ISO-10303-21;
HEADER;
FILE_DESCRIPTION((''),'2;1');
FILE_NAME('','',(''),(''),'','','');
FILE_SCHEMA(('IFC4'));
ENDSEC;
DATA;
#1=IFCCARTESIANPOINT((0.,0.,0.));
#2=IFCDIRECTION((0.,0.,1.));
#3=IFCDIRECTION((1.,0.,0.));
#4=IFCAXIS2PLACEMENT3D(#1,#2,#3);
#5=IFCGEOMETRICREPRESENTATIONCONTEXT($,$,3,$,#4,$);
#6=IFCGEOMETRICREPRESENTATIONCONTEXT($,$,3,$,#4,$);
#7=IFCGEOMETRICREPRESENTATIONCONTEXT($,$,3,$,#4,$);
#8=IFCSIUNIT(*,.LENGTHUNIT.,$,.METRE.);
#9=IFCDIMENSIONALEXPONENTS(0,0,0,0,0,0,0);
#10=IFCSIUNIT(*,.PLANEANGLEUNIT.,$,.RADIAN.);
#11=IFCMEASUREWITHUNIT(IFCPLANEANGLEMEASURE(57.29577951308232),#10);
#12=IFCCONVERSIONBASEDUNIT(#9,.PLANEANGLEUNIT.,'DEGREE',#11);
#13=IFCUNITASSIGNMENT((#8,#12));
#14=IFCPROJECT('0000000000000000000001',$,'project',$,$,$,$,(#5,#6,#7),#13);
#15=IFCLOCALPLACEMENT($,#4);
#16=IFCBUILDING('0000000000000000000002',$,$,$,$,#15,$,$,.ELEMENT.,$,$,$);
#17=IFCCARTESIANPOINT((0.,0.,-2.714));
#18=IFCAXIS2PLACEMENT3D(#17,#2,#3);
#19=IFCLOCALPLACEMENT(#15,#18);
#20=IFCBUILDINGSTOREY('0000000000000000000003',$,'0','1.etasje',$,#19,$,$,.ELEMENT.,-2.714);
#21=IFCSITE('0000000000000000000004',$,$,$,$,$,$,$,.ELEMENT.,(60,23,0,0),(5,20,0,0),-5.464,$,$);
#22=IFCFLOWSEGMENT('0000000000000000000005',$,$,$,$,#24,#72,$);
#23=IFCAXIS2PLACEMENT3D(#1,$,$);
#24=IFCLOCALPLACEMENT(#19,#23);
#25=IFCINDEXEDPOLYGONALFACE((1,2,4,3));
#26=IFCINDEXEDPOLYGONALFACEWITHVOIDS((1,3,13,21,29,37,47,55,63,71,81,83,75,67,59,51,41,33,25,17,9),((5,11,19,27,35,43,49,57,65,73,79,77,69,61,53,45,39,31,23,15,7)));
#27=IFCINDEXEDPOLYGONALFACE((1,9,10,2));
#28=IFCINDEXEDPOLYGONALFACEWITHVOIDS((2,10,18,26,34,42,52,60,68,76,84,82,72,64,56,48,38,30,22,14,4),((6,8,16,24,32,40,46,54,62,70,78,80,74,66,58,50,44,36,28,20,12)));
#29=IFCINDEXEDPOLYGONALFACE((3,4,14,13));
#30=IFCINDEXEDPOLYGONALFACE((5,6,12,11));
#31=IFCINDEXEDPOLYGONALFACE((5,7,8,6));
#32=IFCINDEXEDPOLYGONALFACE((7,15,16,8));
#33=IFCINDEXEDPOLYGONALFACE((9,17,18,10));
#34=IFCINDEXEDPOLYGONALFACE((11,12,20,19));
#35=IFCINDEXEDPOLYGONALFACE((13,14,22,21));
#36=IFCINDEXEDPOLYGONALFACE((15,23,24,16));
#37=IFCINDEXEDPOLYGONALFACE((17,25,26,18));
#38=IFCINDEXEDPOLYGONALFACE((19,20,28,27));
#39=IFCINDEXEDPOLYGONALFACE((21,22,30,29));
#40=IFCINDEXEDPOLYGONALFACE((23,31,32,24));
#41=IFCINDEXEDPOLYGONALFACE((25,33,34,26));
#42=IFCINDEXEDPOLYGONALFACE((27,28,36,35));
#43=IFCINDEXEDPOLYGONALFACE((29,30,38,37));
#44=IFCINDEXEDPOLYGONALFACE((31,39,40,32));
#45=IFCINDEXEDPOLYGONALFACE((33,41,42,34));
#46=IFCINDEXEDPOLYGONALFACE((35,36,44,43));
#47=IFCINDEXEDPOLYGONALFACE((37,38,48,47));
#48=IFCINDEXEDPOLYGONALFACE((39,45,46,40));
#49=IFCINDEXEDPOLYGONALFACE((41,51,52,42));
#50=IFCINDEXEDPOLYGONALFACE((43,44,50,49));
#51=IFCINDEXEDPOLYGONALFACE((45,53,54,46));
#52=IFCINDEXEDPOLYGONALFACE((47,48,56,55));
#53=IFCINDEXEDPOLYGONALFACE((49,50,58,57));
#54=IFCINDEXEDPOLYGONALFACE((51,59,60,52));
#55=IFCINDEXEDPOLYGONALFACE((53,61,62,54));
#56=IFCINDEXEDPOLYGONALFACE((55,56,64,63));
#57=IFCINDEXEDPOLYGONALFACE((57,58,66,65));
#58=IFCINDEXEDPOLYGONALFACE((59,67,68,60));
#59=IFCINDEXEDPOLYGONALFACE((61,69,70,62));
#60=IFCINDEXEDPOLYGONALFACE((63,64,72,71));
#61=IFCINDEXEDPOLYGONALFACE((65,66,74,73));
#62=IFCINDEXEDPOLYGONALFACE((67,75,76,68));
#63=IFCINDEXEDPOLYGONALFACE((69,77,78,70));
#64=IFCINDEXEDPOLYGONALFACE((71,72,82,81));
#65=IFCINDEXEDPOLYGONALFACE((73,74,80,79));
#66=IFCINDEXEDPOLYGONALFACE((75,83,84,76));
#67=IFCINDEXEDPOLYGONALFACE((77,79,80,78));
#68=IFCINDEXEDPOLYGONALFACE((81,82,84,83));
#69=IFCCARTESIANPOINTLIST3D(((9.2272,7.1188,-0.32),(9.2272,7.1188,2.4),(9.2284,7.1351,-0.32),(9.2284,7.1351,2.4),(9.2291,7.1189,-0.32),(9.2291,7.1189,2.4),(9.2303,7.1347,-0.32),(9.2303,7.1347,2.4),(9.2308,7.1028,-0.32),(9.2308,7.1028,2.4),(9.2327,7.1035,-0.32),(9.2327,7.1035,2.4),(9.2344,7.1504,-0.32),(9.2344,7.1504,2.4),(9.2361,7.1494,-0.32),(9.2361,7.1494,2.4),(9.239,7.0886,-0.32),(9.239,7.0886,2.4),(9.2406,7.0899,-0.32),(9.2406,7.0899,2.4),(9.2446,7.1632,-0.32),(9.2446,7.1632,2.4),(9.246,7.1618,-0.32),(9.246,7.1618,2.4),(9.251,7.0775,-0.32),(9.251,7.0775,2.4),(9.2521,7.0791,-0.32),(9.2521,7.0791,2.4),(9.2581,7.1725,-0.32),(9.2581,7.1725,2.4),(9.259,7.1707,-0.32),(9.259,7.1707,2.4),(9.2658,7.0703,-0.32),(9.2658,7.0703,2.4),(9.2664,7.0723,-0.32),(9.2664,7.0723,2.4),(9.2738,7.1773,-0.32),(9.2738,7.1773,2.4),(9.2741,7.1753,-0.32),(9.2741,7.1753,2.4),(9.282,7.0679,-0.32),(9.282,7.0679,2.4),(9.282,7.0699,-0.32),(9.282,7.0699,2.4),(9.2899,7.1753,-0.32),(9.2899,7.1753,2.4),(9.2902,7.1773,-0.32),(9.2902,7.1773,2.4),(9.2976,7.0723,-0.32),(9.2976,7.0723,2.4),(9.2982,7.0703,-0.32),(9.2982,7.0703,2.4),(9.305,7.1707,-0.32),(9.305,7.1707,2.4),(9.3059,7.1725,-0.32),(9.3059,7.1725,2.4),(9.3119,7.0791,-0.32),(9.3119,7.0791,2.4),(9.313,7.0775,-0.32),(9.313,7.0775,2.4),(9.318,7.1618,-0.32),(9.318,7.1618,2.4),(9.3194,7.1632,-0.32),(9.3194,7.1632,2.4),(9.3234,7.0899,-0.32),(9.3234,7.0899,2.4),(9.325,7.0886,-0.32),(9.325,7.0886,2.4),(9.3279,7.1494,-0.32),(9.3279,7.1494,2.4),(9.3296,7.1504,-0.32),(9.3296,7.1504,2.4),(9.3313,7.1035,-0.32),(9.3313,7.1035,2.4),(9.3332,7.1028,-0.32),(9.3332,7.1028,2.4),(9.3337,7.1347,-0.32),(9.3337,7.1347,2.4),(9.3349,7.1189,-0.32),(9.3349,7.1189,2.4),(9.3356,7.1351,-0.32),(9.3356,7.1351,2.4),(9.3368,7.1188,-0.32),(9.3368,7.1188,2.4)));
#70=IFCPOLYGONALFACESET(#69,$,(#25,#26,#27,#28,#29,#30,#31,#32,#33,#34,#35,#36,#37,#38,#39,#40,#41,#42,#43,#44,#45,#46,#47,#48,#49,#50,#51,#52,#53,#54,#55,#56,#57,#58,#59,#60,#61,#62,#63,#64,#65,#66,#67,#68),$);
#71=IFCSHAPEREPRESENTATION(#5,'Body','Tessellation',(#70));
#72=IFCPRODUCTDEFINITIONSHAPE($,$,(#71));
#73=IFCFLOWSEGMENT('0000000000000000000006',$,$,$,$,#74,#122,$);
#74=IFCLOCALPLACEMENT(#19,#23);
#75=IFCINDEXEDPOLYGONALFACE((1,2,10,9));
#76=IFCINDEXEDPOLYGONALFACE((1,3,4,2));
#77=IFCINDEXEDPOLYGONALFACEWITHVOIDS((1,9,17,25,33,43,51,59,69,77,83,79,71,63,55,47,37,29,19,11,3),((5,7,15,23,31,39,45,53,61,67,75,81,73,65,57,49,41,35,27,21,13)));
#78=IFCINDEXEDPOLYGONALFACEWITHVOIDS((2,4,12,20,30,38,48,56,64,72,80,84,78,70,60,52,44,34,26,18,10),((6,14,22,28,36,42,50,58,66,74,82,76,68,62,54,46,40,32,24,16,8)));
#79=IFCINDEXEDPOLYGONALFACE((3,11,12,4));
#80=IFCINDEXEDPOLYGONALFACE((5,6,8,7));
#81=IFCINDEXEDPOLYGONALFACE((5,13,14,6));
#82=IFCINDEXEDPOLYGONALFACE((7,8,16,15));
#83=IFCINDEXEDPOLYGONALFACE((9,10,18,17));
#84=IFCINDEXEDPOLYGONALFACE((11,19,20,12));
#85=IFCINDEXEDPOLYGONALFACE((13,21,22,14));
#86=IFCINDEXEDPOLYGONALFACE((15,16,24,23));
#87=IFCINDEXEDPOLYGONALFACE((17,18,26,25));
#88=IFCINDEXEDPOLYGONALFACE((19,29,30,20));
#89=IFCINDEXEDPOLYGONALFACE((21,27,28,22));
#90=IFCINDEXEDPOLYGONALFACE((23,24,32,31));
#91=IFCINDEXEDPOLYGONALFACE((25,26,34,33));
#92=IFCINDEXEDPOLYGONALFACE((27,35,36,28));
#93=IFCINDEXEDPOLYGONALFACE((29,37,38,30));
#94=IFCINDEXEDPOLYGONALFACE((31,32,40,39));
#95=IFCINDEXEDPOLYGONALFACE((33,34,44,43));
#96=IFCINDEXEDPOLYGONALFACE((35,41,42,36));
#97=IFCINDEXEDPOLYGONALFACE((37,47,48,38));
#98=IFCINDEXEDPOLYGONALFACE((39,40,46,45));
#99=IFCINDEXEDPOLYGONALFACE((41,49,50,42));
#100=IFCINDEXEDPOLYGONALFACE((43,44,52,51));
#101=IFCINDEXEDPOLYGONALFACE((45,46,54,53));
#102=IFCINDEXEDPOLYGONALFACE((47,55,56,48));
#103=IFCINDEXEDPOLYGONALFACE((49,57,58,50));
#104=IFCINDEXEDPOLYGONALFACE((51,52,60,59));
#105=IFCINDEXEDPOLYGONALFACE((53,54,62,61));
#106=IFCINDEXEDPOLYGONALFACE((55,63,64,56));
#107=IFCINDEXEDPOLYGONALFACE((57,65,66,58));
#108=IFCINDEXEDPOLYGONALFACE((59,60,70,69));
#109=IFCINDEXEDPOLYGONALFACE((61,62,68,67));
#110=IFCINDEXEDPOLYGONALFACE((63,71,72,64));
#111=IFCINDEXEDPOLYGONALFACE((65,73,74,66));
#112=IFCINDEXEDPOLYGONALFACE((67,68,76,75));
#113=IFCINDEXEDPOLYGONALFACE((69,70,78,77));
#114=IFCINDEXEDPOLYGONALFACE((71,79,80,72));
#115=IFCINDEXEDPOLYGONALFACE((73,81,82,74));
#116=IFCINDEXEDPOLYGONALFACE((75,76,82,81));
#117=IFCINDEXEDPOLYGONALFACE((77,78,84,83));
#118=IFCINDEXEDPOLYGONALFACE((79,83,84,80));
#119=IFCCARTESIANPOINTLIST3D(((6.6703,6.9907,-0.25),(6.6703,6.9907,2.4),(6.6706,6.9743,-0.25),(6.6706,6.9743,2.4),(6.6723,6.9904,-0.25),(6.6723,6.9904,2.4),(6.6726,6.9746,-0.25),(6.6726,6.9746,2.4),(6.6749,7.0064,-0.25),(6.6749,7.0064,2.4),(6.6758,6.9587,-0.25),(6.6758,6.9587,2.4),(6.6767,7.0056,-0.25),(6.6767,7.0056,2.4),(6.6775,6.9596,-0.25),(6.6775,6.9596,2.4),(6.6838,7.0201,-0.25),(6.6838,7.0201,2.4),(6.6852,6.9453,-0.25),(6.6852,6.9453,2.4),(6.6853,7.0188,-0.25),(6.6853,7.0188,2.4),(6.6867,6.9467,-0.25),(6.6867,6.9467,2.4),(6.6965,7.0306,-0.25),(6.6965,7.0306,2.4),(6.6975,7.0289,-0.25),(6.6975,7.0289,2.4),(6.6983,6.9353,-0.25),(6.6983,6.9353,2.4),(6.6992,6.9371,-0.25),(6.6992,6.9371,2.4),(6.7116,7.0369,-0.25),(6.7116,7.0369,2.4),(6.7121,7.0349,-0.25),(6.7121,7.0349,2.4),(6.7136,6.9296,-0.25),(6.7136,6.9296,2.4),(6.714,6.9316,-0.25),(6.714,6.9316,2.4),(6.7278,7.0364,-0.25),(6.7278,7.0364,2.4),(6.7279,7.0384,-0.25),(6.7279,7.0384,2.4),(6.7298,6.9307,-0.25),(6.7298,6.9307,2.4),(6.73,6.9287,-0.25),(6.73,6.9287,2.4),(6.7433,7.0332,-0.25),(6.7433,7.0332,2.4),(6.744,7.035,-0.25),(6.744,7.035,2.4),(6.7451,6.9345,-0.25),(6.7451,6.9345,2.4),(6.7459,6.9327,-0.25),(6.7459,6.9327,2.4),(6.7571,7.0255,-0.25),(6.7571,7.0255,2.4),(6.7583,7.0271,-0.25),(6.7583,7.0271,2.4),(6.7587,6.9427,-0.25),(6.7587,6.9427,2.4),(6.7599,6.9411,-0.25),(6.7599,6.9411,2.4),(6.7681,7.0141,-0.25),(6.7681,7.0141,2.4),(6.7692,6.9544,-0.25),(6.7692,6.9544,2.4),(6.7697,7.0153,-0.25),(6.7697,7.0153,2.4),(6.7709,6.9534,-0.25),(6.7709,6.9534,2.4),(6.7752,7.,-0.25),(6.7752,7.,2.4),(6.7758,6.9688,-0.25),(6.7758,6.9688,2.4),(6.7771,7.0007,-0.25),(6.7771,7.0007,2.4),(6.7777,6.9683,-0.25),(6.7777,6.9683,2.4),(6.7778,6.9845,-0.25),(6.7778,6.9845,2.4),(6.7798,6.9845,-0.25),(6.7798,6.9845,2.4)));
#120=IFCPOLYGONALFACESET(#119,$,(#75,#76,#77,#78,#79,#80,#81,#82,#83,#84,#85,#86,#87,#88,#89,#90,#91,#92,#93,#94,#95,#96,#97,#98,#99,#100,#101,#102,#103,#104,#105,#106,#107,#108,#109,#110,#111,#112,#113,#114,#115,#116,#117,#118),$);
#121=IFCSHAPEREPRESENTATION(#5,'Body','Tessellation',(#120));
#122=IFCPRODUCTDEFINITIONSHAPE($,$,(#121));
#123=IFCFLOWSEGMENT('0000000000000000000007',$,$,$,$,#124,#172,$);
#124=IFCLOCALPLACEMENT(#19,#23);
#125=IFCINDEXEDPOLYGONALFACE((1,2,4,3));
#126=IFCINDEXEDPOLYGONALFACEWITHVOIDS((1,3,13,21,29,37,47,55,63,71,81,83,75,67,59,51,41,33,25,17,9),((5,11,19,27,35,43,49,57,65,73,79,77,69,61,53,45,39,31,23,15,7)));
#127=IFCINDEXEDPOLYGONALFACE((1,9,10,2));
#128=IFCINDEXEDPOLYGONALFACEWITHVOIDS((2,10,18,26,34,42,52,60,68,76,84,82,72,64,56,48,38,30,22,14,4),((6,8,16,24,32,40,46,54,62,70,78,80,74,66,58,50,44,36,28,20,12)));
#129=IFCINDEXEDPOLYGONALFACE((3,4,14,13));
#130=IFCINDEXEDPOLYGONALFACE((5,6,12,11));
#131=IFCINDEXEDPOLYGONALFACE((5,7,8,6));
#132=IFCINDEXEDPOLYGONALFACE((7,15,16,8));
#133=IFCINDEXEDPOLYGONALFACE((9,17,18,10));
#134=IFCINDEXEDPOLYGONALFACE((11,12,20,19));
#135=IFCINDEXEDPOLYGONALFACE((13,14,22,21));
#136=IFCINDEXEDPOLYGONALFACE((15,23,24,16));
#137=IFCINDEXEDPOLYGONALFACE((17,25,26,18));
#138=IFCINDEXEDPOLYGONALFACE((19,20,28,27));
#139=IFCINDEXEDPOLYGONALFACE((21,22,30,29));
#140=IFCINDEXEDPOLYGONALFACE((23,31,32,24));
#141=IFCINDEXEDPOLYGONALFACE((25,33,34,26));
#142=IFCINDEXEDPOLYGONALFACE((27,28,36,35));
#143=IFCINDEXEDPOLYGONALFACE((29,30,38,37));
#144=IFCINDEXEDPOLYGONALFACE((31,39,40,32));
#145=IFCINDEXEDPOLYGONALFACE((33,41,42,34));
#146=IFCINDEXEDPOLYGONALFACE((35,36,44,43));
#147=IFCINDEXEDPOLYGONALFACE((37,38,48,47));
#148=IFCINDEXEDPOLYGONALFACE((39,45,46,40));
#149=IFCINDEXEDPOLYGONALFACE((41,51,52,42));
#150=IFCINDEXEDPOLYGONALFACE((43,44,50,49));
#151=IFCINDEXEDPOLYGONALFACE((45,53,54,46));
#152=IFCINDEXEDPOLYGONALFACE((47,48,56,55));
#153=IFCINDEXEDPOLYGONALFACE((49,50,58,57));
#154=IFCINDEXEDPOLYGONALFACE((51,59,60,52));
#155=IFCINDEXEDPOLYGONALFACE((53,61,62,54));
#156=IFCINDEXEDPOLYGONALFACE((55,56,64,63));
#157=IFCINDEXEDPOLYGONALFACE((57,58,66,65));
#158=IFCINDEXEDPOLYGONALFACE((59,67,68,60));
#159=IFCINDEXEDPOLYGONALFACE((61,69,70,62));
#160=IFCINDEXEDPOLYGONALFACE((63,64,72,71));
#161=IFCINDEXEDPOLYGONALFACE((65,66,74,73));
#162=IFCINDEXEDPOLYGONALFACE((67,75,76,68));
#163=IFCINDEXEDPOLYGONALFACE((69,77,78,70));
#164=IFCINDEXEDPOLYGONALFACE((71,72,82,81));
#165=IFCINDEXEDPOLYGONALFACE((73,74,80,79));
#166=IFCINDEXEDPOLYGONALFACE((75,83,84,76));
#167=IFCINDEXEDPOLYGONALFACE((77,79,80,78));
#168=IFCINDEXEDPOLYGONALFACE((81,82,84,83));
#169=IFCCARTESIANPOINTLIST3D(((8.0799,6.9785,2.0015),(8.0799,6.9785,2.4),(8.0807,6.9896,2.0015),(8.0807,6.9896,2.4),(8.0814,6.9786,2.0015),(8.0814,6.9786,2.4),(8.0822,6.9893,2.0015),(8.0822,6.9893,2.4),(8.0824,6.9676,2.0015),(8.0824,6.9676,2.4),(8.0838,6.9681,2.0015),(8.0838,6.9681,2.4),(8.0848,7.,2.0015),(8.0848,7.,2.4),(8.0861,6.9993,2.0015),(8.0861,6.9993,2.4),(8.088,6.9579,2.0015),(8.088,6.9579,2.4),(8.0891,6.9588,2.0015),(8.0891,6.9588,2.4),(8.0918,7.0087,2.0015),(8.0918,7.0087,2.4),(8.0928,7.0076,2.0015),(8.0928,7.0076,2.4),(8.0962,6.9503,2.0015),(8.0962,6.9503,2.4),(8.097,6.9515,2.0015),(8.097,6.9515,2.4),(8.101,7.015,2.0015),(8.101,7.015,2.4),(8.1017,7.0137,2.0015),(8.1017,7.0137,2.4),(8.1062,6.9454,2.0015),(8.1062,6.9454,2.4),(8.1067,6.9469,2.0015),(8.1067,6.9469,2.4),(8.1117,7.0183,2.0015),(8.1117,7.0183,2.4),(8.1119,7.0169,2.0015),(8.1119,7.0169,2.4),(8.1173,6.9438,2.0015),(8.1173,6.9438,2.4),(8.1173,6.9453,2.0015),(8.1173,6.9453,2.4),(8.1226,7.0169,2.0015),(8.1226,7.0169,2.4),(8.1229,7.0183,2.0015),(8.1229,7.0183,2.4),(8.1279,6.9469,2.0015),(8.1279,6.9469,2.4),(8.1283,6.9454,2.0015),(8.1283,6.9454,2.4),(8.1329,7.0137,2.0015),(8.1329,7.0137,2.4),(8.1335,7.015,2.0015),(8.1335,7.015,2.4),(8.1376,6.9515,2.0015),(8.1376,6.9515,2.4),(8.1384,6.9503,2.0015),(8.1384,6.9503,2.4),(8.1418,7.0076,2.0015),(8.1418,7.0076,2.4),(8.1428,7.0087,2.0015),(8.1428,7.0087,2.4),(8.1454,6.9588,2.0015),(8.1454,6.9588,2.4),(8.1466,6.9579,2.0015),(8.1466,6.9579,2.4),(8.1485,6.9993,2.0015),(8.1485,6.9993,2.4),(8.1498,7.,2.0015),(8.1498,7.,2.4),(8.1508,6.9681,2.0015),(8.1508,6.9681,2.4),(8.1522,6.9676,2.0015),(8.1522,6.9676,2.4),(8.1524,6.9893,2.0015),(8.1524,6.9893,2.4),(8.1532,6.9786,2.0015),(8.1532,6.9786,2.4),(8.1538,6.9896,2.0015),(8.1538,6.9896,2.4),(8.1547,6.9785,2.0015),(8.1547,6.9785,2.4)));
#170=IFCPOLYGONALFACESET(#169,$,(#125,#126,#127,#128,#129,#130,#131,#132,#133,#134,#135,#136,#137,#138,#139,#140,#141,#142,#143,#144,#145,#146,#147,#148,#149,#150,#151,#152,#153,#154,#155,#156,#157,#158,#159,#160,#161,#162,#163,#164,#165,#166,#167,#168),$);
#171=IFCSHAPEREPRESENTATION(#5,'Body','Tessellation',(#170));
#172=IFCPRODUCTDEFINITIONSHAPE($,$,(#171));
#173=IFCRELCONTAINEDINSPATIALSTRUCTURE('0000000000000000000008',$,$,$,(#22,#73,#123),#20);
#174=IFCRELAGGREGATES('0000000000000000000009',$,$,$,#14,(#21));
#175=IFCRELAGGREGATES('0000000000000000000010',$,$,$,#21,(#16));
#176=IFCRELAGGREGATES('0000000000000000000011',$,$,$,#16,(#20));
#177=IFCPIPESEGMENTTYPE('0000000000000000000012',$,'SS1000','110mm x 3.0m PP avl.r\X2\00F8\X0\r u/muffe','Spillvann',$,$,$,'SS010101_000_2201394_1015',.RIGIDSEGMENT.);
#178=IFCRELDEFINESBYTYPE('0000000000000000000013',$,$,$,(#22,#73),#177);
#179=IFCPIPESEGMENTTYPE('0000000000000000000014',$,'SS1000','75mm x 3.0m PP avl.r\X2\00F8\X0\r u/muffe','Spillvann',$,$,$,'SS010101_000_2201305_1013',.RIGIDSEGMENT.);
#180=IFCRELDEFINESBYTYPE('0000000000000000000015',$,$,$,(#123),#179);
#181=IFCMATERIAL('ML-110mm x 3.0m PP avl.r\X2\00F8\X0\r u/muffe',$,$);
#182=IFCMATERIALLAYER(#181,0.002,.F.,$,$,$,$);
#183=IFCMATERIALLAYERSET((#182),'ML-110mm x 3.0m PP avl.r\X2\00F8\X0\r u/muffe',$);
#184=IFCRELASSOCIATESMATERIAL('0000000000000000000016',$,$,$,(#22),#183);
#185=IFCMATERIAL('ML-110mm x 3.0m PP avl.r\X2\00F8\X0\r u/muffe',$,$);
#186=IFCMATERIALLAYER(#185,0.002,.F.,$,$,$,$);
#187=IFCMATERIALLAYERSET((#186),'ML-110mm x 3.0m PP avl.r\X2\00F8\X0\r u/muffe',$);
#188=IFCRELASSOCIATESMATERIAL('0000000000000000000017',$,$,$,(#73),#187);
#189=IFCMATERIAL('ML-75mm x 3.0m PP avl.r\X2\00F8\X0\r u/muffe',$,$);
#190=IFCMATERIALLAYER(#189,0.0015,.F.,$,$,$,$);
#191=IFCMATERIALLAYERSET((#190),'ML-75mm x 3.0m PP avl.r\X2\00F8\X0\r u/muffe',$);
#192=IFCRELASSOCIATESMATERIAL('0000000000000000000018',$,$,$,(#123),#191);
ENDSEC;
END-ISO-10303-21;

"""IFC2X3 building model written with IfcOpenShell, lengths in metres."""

from ifc_helpers import new_model, entity, si_unit, converted_unit, frame, origin_with_axes, origin_2d_with_axis, place, context, project, spatial, hollow_circle, extrude, material, layer, layer_set, layer_usage, type_object, element, save


model = new_model("IFC2X3")

# Units and contexts
context_of_model_1 = context(None, 3, world=origin_with_axes())
context_of_model_2 = context(None, 3, world=origin_with_axes())
context_of_model_3 = context(None, 3, world=origin_with_axes())
ifc_project = project(units=[si_unit("LENGTHUNIT", "METRE"), converted_unit("PLANEANGLEUNIT", "DEGREE", entity("IfcPlaneAngleMeasure", 57.29577951308232), si_unit("PLANEANGLEUNIT", "RADIAN"), dimensions=[0, 0, 0, 0, 0, 0, 0])], contexts=[context_of_model_1, context_of_model_2, context_of_model_3])

# Site, building, storey
site = spatial("IfcSite", under=ifc_project, CompositionType="ELEMENT", RefLatitude=(60, 23, 0, 0), RefLongitude=(5, 20, 0, 0), RefElevation=-5.464)
building_placement = place(None, origin_with_axes())
building = spatial("IfcBuilding", under=site, at=building_placement, CompositionType="ELEMENT")
storey_placement = place(building_placement, frame((0.0, 0.0, -2.714), z_axis=(0.0, 0.0, 1.0), x_axis=(1.0, 0.0, 0.0)))
storey = spatial("IfcBuildingStorey", under=building, at=storey_placement, Name="0", Description="1.etasje", CompositionType="ELEMENT", Elevation=-2.714)

# Flow segments
ifc_material_1 = material(Name="ML-110mm x 3.0m PP avl.rør u/muffe")
ifc_layer_1 = layer(ifc_material_1, 0.002, ventilated=False)
ifc_layer_set_1 = layer_set([ifc_layer_1], Name="ML-110mm x 3.0m PP avl.rør u/muffe")
ifc_layer_usage_1 = layer_usage(ifc_layer_set_1, "AXIS2", "POSITIVE", 0.0)
pipe_segment_type_1 = type_object("IfcPipeSegmentType", Name="SS1000", Description="110mm x 3.0m PP avl.rør u/muffe", ApplicableOccurrence="Spillvann", ElementType="SS010101_000_2201394_1015", PredefinedType="RIGIDSEGMENT")
flow_segment_1_placement = place(storey_placement, frame((9.282, 7.1229, 2.4), z_axis=(0.0, 0.0, -1.0), x_axis=(0.0, -1.0, 0.0)))
element("IfcFlowSegment", 1, at=flow_segment_1_placement, inside=storey, type_object=pipe_segment_type_1, material=ifc_layer_usage_1, context=context_of_model_1, shape_type="SweptSolid", body=[
    extrude(hollow_circle(Radius=0.055, WallThickness=0.002, at=origin_2d_with_axis()), origin_with_axes(), (0.0, 0.0, 1.0), 2.72),
])
ifc_material_2 = material(Name="ML-110mm x 3.0m PP avl.rør u/muffe")
ifc_layer_2 = layer(ifc_material_2, 0.002, ventilated=False)
ifc_layer_set_2 = layer_set([ifc_layer_2], Name="ML-110mm x 3.0m PP avl.rør u/muffe")
ifc_layer_usage_2 = layer_usage(ifc_layer_set_2, "AXIS2", "POSITIVE", 0.0)
flow_segment_2_placement = place(storey_placement, frame((6.7249, 6.9835, 2.4), z_axis=(0.0, 0.0, -1.0), x_axis=(0.382683, -0.92388, 0.0)))
element("IfcFlowSegment", 2, at=flow_segment_2_placement, inside=storey, type_object=pipe_segment_type_1, material=ifc_layer_usage_2, context=context_of_model_1, shape_type="SweptSolid", body=[
    extrude(hollow_circle(Radius=0.055, WallThickness=0.002, at=origin_2d_with_axis()), origin_with_axes(), (0.0, 0.0, 1.0), 2.65),
])
ifc_material_3 = material(Name="ML-75mm x 3.0m PP avl.rør u/muffe")
ifc_layer_3 = layer(ifc_material_3, 0.0015, ventilated=False)
ifc_layer_set_3 = layer_set([ifc_layer_3], Name="ML-75mm x 3.0m PP avl.rør u/muffe")
ifc_layer_usage_3 = layer_usage(ifc_layer_set_3, "AXIS2", "POSITIVE", 0.0)
pipe_segment_type_2 = type_object("IfcPipeSegmentType", Name="SS1000", Description="75mm x 3.0m PP avl.rør u/muffe", ApplicableOccurrence="Spillvann", ElementType="SS010101_000_2201305_1013", PredefinedType="RIGIDSEGMENT")
flow_segment_3_placement = place(storey_placement, frame((8.1173, 6.9813, 2.4), z_axis=(0.0, 0.0, -1.0), x_axis=(0.0, -1.0, 0.0)))
element("IfcFlowSegment", 3, at=flow_segment_3_placement, inside=storey, type_object=pipe_segment_type_2, material=ifc_layer_usage_3, context=context_of_model_1, shape_type="SweptSolid", body=[
    extrude(hollow_circle(Radius=0.0375, WallThickness=0.0015, at=origin_2d_with_axis()), origin_with_axes(), (0.0, 0.0, 1.0), 0.3985),
])

save(model, "model.ifc")
